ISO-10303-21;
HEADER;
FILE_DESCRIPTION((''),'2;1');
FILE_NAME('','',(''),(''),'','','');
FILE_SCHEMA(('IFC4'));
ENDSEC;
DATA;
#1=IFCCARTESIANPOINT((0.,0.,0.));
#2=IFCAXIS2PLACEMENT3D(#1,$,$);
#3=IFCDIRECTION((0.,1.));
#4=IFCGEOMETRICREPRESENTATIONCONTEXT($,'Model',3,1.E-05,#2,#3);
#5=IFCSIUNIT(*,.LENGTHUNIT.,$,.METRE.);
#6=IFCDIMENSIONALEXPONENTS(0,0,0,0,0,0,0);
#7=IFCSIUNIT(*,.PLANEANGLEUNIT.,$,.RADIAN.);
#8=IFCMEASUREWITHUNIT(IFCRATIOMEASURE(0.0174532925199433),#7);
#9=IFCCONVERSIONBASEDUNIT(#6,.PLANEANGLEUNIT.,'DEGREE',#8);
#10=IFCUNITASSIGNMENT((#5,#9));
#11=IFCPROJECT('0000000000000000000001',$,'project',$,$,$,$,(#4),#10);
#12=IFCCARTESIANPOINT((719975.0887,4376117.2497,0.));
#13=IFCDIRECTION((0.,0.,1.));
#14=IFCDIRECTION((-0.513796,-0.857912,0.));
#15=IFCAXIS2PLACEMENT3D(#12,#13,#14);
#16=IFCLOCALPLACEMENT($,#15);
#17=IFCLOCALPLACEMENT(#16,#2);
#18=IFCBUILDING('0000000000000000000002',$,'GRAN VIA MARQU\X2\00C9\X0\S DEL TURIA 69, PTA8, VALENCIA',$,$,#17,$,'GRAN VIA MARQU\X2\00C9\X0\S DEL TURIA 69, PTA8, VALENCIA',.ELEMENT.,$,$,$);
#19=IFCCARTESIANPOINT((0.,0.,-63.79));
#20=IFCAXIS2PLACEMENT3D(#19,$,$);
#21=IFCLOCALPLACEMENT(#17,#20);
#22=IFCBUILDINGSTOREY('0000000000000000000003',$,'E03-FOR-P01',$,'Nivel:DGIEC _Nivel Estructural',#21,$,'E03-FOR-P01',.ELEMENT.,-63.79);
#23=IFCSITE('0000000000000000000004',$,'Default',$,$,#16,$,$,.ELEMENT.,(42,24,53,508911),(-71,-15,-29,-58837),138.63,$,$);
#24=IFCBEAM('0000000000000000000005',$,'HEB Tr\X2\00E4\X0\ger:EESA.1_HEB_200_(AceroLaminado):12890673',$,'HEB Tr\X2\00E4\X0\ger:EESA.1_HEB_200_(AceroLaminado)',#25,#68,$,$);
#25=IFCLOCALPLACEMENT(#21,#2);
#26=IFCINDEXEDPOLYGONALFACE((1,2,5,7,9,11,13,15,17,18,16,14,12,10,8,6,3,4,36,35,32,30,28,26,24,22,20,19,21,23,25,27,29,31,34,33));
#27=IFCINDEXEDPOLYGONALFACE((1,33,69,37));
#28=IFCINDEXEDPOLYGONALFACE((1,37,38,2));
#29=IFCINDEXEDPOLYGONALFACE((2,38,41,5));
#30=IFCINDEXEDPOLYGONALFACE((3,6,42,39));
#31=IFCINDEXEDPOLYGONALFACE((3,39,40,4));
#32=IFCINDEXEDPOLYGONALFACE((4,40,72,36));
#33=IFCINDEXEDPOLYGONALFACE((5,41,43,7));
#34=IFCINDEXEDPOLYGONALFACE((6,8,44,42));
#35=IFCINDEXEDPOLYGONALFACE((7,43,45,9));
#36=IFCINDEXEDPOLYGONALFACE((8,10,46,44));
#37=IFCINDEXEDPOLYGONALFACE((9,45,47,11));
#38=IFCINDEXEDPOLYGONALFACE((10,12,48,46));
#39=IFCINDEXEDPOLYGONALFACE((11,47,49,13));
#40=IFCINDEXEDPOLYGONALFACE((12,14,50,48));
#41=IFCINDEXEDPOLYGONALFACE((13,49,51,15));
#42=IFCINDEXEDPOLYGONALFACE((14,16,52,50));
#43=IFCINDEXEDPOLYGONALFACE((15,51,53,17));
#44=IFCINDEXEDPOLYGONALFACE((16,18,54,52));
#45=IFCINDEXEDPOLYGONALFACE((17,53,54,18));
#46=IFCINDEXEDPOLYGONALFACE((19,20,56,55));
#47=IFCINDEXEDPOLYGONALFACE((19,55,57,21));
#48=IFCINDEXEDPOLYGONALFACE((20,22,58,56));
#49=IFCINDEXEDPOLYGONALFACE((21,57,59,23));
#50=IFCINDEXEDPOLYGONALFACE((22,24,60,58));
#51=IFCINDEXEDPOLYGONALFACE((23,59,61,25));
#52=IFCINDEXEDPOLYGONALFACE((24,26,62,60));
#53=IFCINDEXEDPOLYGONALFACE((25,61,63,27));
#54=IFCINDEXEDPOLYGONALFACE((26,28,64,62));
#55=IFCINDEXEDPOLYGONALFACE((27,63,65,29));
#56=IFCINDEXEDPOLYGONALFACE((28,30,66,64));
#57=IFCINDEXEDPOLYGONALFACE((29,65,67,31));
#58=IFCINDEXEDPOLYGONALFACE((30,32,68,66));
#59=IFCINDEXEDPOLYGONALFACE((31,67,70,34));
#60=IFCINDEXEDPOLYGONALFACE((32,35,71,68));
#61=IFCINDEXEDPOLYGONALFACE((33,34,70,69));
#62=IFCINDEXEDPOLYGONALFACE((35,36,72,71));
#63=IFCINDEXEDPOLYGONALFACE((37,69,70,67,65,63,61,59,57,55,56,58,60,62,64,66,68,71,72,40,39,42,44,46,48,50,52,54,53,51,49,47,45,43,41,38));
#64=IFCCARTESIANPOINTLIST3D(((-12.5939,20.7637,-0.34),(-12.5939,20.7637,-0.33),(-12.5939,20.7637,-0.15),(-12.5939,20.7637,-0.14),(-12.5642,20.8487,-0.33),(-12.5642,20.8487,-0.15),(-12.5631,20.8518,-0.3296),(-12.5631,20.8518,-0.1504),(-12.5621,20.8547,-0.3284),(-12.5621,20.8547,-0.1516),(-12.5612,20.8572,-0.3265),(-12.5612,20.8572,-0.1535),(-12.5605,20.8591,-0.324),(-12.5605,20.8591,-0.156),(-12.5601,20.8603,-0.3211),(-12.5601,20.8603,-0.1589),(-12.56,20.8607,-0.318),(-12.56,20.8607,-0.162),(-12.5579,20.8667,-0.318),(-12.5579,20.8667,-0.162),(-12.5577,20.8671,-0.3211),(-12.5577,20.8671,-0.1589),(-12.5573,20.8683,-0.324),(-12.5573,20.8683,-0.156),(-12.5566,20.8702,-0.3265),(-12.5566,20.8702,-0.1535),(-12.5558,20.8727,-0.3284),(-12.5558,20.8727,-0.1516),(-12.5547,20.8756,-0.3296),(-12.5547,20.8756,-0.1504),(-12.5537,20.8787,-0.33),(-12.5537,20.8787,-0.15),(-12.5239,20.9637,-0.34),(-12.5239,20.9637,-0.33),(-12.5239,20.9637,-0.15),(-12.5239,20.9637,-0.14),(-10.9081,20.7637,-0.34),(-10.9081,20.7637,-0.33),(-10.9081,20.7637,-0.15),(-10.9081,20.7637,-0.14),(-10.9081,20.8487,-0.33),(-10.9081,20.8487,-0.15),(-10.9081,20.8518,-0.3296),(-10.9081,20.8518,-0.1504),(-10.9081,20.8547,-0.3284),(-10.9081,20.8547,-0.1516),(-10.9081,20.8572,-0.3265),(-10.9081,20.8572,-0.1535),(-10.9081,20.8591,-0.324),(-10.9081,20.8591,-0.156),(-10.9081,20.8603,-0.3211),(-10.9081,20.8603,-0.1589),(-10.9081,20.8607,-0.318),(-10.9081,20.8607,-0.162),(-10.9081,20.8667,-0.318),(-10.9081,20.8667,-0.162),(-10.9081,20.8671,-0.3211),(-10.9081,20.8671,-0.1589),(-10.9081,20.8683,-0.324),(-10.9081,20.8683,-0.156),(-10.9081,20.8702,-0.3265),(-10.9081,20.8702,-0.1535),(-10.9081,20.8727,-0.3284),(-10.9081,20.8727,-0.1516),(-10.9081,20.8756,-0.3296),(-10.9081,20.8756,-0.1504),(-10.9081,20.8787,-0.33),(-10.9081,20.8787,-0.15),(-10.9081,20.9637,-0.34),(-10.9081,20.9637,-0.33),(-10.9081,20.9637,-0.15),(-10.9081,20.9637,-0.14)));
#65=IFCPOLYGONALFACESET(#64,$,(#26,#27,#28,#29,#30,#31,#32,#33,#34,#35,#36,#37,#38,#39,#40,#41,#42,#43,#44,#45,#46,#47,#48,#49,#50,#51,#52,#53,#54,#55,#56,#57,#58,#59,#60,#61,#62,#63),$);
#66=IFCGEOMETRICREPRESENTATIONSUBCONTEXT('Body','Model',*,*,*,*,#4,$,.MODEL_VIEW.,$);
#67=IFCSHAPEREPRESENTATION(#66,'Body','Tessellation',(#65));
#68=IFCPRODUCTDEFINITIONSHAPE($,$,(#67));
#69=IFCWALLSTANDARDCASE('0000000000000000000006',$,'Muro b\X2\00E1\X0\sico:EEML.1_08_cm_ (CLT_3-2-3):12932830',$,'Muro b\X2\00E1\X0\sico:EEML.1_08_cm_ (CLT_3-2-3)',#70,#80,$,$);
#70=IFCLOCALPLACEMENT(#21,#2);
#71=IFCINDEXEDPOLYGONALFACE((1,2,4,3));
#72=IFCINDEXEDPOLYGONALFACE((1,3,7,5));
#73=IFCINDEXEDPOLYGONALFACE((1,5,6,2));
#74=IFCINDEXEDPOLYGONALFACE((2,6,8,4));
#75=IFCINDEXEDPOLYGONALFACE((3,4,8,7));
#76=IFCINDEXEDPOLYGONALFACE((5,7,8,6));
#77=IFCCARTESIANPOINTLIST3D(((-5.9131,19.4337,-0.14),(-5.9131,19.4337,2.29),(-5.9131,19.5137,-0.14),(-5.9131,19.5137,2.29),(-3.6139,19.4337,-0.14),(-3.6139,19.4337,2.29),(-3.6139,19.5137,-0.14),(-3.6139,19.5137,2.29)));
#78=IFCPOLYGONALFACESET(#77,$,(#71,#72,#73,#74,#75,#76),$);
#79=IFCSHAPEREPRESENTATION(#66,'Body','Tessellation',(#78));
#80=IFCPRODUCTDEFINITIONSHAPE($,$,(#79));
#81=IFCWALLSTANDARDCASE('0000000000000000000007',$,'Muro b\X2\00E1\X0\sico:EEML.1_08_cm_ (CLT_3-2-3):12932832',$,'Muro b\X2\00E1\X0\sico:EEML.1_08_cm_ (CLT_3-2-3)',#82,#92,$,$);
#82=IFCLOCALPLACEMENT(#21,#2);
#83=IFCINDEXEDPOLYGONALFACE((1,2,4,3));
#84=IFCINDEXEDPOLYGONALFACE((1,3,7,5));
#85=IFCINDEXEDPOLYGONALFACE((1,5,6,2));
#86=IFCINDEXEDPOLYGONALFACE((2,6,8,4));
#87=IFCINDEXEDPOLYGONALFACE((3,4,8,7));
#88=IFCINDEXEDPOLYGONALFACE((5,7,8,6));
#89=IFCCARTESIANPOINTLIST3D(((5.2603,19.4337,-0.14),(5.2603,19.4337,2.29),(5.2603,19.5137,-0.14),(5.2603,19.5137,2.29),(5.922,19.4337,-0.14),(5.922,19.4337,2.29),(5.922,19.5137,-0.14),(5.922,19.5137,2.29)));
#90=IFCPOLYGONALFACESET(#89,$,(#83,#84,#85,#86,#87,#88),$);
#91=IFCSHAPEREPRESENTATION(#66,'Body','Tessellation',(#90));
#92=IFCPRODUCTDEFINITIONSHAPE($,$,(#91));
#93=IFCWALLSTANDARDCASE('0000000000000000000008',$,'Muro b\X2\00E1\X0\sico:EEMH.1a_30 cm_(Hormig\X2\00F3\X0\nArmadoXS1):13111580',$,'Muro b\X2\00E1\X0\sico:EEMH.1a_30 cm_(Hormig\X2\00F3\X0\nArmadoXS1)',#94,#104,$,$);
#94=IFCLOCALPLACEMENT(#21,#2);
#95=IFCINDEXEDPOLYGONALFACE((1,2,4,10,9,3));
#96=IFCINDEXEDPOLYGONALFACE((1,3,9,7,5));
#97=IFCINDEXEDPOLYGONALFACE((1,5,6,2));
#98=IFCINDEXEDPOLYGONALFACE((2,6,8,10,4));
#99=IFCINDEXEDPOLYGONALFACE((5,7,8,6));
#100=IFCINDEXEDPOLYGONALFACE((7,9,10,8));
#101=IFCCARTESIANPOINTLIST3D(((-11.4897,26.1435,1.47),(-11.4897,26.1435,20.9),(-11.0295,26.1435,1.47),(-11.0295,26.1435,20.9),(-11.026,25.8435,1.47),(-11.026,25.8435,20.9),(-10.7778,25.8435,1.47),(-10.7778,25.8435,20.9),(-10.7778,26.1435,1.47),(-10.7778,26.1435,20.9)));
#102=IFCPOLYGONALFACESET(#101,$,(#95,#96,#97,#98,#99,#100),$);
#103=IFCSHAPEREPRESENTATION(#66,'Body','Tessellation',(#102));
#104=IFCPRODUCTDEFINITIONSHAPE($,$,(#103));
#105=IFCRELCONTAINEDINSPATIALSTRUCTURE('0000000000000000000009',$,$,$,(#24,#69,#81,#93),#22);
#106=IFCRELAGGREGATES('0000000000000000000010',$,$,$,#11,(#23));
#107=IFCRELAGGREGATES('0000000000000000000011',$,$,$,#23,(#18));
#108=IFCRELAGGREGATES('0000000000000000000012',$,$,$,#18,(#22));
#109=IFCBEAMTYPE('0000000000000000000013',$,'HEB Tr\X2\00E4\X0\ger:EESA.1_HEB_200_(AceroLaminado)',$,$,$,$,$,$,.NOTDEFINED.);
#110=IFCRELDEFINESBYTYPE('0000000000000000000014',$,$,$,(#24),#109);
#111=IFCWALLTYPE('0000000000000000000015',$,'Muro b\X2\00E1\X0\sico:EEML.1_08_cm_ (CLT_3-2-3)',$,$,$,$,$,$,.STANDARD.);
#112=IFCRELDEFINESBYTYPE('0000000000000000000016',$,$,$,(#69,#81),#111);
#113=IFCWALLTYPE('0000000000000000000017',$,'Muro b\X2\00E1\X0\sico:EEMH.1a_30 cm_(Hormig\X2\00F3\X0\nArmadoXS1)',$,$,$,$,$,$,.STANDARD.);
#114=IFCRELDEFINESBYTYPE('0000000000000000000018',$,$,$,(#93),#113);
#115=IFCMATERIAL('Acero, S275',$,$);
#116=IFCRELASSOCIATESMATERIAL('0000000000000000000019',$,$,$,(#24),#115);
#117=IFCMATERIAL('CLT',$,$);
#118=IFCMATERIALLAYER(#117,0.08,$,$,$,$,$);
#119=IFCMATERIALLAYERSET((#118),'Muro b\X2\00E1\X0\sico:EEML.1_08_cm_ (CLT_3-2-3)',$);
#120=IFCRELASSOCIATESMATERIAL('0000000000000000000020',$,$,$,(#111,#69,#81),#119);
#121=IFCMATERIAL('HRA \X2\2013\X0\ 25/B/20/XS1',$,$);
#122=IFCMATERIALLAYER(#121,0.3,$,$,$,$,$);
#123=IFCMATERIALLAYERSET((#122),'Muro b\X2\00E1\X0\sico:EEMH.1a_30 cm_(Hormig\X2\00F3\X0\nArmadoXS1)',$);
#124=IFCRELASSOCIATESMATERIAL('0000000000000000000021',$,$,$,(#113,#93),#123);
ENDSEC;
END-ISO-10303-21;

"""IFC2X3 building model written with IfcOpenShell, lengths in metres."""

from ifc_helpers import new_model, entity, si_unit, converted_unit, direction, frame, frame_2d, origin, place, context, subcontext, project, spatial, polyline, rectangle, i_section, outline, extrude, clip, halfspace, material, layer, layer_set, layer_usage, type_object, element, save


model = new_model("IFC2X3")

# Units and contexts
model_context = context("Model", 3, precision=1e-05, world=origin(), true_north=direction((0.0, 1.0)))
body_context = subcontext(model_context, "Body", "Model", "MODEL_VIEW")
ifc_project = project(units=[si_unit("LENGTHUNIT", "METRE"), converted_unit("PLANEANGLEUNIT", "DEGREE", entity("IfcRatioMeasure", 0.0174532925199433), si_unit("PLANEANGLEUNIT", "RADIAN"), dimensions=[0, 0, 0, 0, 0, 0, 0])], contexts=[model_context])

# Site, building, storey
site_placement = place(None, frame((719975.0887, 4376117.2497, 0.0), z_axis=(0.0, 0.0, 1.0), x_axis=(-0.513796, -0.857912, 0.0)))
site = spatial("IfcSite", under=ifc_project, at=site_placement, Name="Default", CompositionType="ELEMENT", RefLatitude=(42, 24, 53, 508911), RefLongitude=(-71, -15, -29, -58837), RefElevation=138.63)
building_placement = place(site_placement, origin())
building = spatial("IfcBuilding", under=site, at=building_placement, Name="GRAN VIA MARQUÉS DEL TURIA 69, PTA8, VALENCIA", LongName="GRAN VIA MARQUÉS DEL TURIA 69, PTA8, VALENCIA", CompositionType="ELEMENT")
storey_placement = place(building_placement, frame((0.0, 0.0, -63.79)))
storey = spatial("IfcBuildingStorey", under=building, at=storey_placement, Name="E03-FOR-P01", ObjectType="Nivel:DGIEC _Nivel Estructural", LongName="E03-FOR-P01", CompositionType="ELEMENT", Elevation=-63.79)

# Shared definitions
ifc_material_1 = material(Name="Acero, S275")

# Beam
beam_type = type_object("IfcBeamType", Name="HEB Träger:EESA.1_HEB_200_(AceroLaminado)", PredefinedType="NOTDEFINED")
beam_placement = place(storey_placement, frame((-10.908, 20.8637, 0.0), z_axis=(0.0, 0.0, 1.0), x_axis=(-1.0, 0.0, 0.0)))
element("IfcBeam", 1, at=beam_placement, inside=storey, type_object=beam_type, material=ifc_material_1, Name="HEB Träger:EESA.1_HEB_200_(AceroLaminado):12890673", ObjectType="HEB Träger:EESA.1_HEB_200_(AceroLaminado)", context=body_context, shape_type="Clipping", body=[
    clip(extrude(i_section(OverallWidth=0.2, OverallDepth=0.2, WebThickness=0.006, FlangeThickness=0.01, FilletRadius=0.012, at=frame_2d((0.0, 0.0), x_axis=(0.0, 1.0))), frame((0.0, 0.0, -0.24), z_axis=(1.0, 0.0, 0.0), x_axis=(0.0, 0.0, -1.0)), (0.0, 0.0, 1.0), 1.6859), halfspace(frame((1.6158, -0.1, -1.9968), z_axis=(0.943797, -0.330527, 0.0), x_axis=(0.0, 0.0, 1.0)), False)),
])

# Walls
ifc_material_2 = material(Name="CLT")
ifc_layer_1 = layer(ifc_material_2, 0.08)
ifc_layer_set_1 = layer_set([ifc_layer_1], Name="Muro básico:EEML.1_08_cm_ (CLT_3-2-3)")
ifc_layer_usage_1 = layer_usage(ifc_layer_set_1, "AXIS2", "NEGATIVE", 0.04)
wall_type_1 = type_object("IfcWallType", Name="Muro básico:EEML.1_08_cm_ (CLT_3-2-3)", PredefinedType="STANDARD", material=ifc_layer_set_1)
wall_1_placement = place(storey_placement, frame((-3.6139, 19.4737, -0.14), z_axis=(0.0, 0.0, 1.0), x_axis=(-1.0, 0.0, 0.0)))
element("IfcWallStandardCase", 2, at=wall_1_placement, inside=storey, type_object=wall_type_1, material=ifc_layer_usage_1, Name="Muro básico:EEML.1_08_cm_ (CLT_3-2-3):12932830", ObjectType="Muro básico:EEML.1_08_cm_ (CLT_3-2-3)", context=body_context, shape_type="SweptSolid", body=[
    extrude(rectangle(XDim=2.2992, YDim=0.08, at=frame_2d((1.1496, 0.0), x_axis=(-1.0, 0.0))), origin(), (0.0, 0.0, 1.0), 2.43),
])
ifc_layer_usage_2 = layer_usage(ifc_layer_set_1, "AXIS2", "NEGATIVE", 0.04)
wall_2_placement = place(storey_placement, frame((5.922, 19.4737, -0.14), z_axis=(0.0, 0.0, 1.0), x_axis=(-1.0, 0.0, 0.0)))
element("IfcWallStandardCase", 3, at=wall_2_placement, inside=storey, type_object=wall_type_1, material=ifc_layer_usage_2, Name="Muro básico:EEML.1_08_cm_ (CLT_3-2-3):12932832", ObjectType="Muro básico:EEML.1_08_cm_ (CLT_3-2-3)", context=body_context, shape_type="SweptSolid", body=[
    extrude(rectangle(XDim=0.6617, YDim=0.08, at=frame_2d((0.3308, 0.0), x_axis=(-1.0, 0.0))), origin(), (0.0, 0.0, 1.0), 2.43),
])
ifc_material_3 = material(Name="HRA – 25/B/20/XS1")
ifc_layer_2 = layer(ifc_material_3, 0.3)
ifc_layer_set_2 = layer_set([ifc_layer_2], Name="Muro básico:EEMH.1a_30 cm_(HormigónArmadoXS1)")
ifc_layer_usage_3 = layer_usage(ifc_layer_set_2, "AXIS2", "POSITIVE", -0.15)
wall_type_2 = type_object("IfcWallType", Name="Muro básico:EEMH.1a_30 cm_(HormigónArmadoXS1)", PredefinedType="STANDARD", material=ifc_layer_set_2)
wall_3_placement = place(storey_placement, frame((-11.4897, 25.9935, 1.47)))
element("IfcWallStandardCase", 4, at=wall_3_placement, inside=storey, type_object=wall_type_2, material=ifc_layer_usage_3, Name="Muro básico:EEMH.1a_30 cm_(HormigónArmadoXS1):13111580", ObjectType="Muro básico:EEMH.1a_30 cm_(HormigónArmadoXS1)", context=body_context, shape_type="SweptSolid", body=[
    extrude(outline(polyline([(0.712, -0.15), (0.712, 0.15), (0.4602, 0.15), (0.0, 0.15), (0.4637, -0.15), (0.712, -0.15)])), origin(), (0.0, 0.0, 1.0), 19.43),
])

save(model, "model.ifc")
